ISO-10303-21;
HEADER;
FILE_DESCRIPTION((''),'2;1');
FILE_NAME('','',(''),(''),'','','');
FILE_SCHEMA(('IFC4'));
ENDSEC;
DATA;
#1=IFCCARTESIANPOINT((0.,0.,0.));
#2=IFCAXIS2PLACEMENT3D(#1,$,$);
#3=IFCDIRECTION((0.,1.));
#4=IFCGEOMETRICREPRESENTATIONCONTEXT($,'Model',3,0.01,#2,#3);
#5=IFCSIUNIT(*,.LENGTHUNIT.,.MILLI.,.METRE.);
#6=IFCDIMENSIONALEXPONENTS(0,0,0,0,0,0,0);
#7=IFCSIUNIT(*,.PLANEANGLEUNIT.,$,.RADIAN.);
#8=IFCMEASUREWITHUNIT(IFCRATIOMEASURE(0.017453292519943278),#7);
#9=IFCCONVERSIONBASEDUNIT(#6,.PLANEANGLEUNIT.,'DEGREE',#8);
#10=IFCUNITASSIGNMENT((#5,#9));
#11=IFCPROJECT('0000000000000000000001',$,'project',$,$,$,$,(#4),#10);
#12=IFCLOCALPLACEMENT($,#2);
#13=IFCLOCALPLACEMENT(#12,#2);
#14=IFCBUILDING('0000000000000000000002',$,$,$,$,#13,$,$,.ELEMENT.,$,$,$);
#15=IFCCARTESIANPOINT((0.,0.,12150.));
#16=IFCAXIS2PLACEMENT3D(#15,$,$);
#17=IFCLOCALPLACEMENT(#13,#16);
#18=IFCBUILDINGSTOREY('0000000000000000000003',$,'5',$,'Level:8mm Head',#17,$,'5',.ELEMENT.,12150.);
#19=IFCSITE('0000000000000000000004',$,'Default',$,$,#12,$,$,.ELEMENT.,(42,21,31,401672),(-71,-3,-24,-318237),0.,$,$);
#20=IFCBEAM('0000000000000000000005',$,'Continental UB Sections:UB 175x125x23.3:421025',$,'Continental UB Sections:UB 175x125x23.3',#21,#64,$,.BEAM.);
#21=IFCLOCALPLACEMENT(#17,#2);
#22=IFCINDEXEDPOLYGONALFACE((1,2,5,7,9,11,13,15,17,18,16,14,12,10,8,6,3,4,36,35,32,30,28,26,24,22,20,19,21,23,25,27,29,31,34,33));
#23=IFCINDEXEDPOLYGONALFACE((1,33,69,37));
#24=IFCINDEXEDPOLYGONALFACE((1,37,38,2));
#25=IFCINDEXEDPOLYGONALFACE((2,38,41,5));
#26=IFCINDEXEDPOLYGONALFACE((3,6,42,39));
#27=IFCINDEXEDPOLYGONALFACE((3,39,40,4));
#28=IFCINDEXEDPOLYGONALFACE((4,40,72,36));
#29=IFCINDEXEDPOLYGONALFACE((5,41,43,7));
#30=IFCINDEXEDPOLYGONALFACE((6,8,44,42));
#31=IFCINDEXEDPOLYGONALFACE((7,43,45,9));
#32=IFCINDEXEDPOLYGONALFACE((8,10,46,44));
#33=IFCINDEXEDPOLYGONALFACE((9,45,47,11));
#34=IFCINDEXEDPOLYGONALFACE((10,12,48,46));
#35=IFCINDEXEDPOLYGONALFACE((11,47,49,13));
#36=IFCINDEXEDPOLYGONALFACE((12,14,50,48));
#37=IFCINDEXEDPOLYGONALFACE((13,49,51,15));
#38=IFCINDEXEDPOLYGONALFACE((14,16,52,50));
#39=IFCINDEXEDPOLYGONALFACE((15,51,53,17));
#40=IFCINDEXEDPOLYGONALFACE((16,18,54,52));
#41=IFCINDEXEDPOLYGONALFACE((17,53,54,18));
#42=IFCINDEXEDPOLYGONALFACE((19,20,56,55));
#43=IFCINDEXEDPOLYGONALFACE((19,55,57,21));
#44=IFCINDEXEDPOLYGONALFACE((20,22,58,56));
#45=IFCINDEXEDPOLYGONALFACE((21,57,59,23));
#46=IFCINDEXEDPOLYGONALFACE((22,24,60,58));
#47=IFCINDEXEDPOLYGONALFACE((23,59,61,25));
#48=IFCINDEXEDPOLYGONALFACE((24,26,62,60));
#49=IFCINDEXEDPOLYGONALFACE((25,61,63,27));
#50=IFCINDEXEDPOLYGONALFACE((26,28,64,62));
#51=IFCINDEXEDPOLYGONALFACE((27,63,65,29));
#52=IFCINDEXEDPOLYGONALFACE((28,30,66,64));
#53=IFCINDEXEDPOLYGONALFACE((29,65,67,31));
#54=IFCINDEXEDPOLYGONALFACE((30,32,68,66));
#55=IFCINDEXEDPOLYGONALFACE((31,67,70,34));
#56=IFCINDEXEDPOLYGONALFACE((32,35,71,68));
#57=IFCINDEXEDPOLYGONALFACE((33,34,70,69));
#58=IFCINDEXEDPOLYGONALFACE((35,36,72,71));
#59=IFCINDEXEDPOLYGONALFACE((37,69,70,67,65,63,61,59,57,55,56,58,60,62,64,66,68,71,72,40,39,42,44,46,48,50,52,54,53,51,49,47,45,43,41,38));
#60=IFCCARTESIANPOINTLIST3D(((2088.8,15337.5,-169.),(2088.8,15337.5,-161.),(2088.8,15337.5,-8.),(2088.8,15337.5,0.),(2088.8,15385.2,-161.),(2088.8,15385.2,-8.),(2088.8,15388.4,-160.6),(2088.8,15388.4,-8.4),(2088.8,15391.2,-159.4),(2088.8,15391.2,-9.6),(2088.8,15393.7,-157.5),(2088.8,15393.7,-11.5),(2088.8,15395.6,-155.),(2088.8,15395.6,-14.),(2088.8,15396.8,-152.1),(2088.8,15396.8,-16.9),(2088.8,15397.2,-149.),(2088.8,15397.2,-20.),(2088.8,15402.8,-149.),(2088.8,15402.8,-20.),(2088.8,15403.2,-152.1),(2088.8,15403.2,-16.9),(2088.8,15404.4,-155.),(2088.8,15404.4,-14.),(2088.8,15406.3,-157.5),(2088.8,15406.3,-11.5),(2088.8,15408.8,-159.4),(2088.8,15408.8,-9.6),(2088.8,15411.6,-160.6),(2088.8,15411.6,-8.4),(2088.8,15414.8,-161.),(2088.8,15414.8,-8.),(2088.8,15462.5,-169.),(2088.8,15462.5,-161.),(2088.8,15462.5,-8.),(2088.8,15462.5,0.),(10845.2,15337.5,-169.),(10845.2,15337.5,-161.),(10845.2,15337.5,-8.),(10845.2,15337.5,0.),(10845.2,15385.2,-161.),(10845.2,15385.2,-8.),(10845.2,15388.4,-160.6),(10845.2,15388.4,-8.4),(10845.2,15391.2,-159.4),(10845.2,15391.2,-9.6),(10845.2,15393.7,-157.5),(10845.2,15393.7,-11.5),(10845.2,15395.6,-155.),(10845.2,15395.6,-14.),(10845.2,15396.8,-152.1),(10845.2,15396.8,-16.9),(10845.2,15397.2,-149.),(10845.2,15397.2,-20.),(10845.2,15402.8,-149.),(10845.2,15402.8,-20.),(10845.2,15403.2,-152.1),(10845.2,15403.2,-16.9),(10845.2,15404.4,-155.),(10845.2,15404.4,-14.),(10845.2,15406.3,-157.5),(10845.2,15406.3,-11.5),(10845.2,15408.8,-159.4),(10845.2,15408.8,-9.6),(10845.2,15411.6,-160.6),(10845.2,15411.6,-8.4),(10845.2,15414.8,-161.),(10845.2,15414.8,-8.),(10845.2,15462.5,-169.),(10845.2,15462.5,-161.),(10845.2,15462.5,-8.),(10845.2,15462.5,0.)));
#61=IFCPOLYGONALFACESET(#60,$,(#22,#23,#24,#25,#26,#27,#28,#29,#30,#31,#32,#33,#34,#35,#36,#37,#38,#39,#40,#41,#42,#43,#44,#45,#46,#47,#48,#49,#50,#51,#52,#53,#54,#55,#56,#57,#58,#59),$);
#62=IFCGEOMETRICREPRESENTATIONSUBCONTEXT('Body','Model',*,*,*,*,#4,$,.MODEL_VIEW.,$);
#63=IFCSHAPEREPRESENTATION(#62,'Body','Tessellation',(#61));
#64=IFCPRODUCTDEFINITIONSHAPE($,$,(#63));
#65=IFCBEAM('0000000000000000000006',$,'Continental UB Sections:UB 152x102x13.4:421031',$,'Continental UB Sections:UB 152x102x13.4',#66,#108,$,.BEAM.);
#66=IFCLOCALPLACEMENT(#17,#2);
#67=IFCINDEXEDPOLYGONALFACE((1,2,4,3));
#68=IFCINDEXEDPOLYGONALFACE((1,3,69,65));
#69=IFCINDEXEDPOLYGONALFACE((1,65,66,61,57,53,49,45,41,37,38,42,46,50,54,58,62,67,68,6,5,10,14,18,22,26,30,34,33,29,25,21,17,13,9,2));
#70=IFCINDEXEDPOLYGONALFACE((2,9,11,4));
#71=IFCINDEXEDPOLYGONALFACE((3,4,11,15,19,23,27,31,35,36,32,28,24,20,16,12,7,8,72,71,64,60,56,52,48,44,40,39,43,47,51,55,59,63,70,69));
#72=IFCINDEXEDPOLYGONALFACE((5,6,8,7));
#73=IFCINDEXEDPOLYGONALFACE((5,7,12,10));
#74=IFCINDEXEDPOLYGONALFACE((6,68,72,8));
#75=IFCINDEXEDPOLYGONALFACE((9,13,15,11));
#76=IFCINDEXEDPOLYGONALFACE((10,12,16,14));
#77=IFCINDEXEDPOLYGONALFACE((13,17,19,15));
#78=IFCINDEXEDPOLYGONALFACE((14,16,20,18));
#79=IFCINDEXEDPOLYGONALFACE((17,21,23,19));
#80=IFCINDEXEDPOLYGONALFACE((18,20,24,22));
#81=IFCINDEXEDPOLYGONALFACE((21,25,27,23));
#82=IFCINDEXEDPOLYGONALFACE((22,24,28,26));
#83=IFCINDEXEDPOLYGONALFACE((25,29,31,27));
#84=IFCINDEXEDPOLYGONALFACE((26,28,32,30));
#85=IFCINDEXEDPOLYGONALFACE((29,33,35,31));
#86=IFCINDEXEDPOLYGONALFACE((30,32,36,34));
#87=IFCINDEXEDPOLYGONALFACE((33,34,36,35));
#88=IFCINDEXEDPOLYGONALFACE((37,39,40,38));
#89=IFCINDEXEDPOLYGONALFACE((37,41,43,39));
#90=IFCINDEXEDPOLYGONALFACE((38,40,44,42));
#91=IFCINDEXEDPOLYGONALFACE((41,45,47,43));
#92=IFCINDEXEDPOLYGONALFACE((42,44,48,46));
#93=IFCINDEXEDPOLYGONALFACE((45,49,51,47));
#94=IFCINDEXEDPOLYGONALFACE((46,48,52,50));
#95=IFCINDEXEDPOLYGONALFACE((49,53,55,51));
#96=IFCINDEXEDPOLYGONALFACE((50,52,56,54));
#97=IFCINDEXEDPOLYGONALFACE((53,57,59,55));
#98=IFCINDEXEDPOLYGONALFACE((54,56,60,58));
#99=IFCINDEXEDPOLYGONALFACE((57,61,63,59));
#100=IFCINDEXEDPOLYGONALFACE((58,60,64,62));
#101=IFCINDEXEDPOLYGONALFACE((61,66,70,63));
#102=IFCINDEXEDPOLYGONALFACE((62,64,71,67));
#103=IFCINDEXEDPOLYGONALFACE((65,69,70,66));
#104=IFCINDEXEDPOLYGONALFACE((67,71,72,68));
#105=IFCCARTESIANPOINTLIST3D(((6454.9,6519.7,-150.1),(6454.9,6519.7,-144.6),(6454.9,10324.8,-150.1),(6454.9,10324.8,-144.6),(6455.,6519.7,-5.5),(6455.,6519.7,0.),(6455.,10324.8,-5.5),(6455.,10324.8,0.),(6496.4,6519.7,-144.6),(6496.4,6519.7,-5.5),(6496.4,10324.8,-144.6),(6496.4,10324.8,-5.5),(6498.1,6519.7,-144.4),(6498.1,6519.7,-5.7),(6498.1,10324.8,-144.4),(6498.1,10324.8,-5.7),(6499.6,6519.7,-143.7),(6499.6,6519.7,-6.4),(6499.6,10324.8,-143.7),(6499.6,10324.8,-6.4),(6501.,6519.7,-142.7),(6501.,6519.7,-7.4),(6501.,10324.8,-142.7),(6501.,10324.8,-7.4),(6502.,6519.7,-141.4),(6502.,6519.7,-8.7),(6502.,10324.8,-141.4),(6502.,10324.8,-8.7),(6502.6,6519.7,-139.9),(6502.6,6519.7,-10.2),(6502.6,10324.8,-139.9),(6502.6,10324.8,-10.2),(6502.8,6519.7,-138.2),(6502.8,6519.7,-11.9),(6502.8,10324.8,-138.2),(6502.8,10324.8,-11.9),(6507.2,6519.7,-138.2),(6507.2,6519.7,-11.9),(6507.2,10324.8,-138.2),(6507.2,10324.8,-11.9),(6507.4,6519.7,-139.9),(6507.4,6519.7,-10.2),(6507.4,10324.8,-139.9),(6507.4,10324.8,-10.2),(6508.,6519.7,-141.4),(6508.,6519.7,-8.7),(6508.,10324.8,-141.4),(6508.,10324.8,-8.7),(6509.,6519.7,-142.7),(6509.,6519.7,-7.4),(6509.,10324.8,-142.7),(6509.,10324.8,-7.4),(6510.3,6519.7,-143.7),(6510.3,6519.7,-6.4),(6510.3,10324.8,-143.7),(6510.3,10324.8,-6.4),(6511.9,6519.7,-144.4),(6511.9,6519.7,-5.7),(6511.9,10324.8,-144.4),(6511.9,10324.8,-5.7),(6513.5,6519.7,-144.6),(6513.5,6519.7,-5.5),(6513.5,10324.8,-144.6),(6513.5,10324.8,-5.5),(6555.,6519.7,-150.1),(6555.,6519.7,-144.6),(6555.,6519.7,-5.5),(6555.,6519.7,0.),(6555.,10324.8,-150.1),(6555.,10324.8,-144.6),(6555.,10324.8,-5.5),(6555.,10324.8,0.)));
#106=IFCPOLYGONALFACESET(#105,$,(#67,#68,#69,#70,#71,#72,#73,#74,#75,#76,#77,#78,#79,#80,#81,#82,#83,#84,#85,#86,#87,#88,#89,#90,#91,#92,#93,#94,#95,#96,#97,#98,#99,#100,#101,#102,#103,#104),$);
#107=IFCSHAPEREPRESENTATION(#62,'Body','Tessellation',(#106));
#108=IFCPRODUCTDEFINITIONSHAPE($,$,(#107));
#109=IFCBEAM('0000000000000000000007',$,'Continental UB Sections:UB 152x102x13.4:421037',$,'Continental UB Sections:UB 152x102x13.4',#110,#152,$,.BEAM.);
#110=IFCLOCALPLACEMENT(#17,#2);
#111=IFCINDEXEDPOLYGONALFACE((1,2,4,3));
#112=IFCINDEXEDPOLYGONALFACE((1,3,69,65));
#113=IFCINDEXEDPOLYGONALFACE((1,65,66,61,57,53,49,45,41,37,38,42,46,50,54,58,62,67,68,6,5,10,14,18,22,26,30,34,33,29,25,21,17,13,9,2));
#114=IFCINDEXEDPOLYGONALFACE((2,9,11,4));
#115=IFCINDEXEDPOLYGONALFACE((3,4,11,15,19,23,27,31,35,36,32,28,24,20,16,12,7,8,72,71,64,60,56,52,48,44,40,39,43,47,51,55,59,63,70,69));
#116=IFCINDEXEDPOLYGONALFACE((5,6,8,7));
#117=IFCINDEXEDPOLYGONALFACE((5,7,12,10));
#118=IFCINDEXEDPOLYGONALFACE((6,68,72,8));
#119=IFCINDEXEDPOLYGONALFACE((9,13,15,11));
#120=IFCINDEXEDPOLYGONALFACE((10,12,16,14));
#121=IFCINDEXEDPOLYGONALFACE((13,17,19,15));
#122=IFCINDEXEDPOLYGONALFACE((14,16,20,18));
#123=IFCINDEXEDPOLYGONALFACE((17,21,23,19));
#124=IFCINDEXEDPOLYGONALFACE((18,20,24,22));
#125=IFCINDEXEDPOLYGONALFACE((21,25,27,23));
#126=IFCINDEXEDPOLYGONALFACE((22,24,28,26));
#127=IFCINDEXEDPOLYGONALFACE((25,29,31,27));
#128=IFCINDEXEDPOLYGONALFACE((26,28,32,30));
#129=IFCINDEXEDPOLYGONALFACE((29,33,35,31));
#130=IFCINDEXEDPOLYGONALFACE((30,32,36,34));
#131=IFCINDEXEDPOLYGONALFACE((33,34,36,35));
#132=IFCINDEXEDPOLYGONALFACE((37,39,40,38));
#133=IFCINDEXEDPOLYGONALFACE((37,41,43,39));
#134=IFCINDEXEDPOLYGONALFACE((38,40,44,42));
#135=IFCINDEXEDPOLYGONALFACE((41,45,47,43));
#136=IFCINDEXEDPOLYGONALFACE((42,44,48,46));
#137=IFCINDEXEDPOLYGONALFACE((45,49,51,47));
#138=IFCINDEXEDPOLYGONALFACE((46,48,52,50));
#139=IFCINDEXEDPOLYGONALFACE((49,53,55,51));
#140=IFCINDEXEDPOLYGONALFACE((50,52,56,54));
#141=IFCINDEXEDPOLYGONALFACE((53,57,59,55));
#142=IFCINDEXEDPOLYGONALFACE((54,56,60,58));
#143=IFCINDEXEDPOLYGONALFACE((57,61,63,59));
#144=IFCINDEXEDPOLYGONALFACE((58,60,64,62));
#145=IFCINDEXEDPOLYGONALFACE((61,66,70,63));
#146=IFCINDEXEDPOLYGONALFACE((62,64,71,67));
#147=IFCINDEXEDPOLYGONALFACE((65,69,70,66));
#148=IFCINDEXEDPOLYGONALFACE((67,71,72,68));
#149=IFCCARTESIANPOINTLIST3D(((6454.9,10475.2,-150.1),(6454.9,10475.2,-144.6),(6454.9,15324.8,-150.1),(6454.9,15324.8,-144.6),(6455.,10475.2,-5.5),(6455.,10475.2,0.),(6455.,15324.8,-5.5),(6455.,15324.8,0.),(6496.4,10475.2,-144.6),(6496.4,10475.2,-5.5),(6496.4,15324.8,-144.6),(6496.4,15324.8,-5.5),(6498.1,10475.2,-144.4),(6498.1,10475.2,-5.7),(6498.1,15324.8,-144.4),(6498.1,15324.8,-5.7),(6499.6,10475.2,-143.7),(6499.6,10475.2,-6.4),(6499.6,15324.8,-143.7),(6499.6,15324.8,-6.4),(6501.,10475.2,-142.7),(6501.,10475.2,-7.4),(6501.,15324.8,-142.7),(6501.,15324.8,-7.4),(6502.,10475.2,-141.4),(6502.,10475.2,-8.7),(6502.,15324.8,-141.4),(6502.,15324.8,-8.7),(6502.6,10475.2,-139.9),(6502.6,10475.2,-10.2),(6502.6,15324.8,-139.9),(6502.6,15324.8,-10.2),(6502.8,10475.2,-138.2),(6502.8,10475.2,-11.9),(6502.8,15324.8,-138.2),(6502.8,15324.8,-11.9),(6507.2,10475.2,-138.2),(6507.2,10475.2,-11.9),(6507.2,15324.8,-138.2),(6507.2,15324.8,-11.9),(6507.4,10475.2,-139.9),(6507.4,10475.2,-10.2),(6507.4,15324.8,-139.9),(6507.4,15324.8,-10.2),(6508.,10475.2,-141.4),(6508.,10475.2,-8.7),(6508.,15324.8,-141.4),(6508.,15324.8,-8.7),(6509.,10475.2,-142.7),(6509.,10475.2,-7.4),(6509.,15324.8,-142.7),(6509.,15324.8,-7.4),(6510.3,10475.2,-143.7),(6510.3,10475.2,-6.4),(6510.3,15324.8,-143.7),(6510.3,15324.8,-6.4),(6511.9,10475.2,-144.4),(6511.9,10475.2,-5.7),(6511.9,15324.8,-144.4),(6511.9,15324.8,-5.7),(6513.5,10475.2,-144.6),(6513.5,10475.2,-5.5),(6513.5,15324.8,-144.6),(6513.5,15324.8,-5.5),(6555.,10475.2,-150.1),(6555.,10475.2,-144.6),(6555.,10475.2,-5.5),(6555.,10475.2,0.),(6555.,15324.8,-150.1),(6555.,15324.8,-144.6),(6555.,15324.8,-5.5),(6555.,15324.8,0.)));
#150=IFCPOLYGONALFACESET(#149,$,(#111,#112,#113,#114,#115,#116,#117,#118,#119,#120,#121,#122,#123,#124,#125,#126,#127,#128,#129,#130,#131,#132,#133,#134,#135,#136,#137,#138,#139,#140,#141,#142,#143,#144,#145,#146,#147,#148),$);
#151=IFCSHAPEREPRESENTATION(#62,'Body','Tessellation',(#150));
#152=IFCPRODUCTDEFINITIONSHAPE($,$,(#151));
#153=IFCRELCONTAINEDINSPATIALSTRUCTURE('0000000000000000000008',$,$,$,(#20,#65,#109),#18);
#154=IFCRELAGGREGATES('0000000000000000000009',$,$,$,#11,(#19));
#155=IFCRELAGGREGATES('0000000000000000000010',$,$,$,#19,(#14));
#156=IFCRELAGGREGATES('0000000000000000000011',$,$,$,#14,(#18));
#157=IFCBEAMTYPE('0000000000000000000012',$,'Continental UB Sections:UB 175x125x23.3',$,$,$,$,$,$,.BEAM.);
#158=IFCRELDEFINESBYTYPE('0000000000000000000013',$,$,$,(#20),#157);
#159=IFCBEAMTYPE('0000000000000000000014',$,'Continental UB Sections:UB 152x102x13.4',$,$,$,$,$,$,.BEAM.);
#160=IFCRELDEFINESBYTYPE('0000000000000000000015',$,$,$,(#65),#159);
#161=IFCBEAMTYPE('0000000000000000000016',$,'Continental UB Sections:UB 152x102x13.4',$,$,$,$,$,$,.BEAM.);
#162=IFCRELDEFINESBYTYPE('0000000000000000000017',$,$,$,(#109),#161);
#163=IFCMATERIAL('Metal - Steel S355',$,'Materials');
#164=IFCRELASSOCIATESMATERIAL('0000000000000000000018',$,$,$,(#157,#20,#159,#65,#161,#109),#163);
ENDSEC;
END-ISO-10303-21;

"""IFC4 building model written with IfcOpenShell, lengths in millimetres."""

from ifc_helpers import new_model, entity, si_unit, converted_unit, direction, frame, origin, place, context, subcontext, project, spatial, line, arc, indexed_curve, outline, extrude, source, transform, mapped, material, type_object, type_shapes, element, save


model = new_model("IFC4")

# Units and contexts
model_context = context("Model", 3, precision=0.01, world=origin(), true_north=direction((0.0, 1.0)))
body_context = subcontext(model_context, "Body", "Model", "MODEL_VIEW")
ifc_project = project(units=[si_unit("LENGTHUNIT", "METRE", prefix="MILLI"), converted_unit("PLANEANGLEUNIT", "DEGREE", entity("IfcRatioMeasure", 0.017453292519943278), si_unit("PLANEANGLEUNIT", "RADIAN"), dimensions=[0, 0, 0, 0, 0, 0, 0])], contexts=[model_context])

# Site, building, storey
site_placement = place(None, origin())
site = spatial("IfcSite", under=ifc_project, at=site_placement, Name="Default", CompositionType="ELEMENT", RefLatitude=(42, 21, 31, 401672), RefLongitude=(-71, -3, -24, -318237), RefElevation=0.0)
building_placement = place(site_placement, origin())
building = spatial("IfcBuilding", under=site, at=building_placement, CompositionType="ELEMENT")
storey_placement = place(building_placement, frame((0.0, 0.0, 12150.0)))
storey = spatial("IfcBuildingStorey", under=building, at=storey_placement, Name="5", ObjectType="Level:8mm Head", LongName="5", CompositionType="ELEMENT", Elevation=12150.0)

# Beams
ifc_material = material(Name="Metal - Steel S355", Category="Materials")
beam_type_1 = type_object("IfcBeamType", Name="Continental UB Sections:UB 175x125x23.3", PredefinedType="BEAM", material=ifc_material)
shared_shape_1 = source(origin(), body_context, "Body", "SweptSolid", [
    extrude(outline(indexed_curve([(-84.5, -62.5), (-76.5, -62.5), (-76.5, -14.8), (-73.0, -6.3), (-64.5, -2.7), (64.5, -2.7), (73.0, -6.3), (76.5, -14.7), (76.5, -62.5), (84.5, -62.5), (84.5, 62.5), (76.5, 62.5), (76.5, 14.8), (73.0, 6.3), (64.5, 2.8), (-64.5, 2.8), (-73.0, 6.3), (-76.5, 14.8), (-76.5, 62.5), (-84.5, 62.5)], segments=[line(1, 2, 3), arc(3, 4, 5), line(5, 6), arc(6, 7, 8), line(8, 9, 10, 11, 12, 13), arc(13, 14, 15), line(15, 16), arc(16, 17, 18), line(18, 19, 20, 1)], self_intersect=False)), frame((-4416.2, 0.0, 0.0), z_axis=(1.0, 0.0, 0.0), x_axis=(0.0, 0.0, -1.0)), (0.0, 0.0, 1.0), 8756.4),
])
type_shapes(beam_type_1, [shared_shape_1])
for number, where, name in (
    (1, (6505.0, 15400.0, -84.5), "Continental UB Sections:UB 175x125x23.3:421025"),
):
    element("IfcBeam", number, at=place(storey_placement, frame(where)), inside=storey, type_object=beam_type_1, material=ifc_material, Name=name, ObjectType="Continental UB Sections:UB 175x125x23.3", PredefinedType="BEAM", context=body_context, shape_type="MappedRepresentation", body=[
        mapped(shared_shape_1, transform((0.0, 0.0, 0.0), scale=1.0)),
    ])
beam_type_2 = type_object("IfcBeamType", Name="Continental UB Sections:UB 152x102x13.4", PredefinedType="BEAM", material=ifc_material)
shared_shape_2 = source(origin(), body_context, "Body", "SweptSolid", [
    extrude(outline(indexed_curve([(-75.0, -50.1), (-69.6, -50.1), (-69.6, -8.5), (-67.7, -4.0), (-63.2, -2.1), (63.1, -2.1), (67.7, -4.0), (69.5, -8.5), (69.5, -50.1), (75.1, -50.1), (75.1, 50.1), (69.5, 50.1), (69.5, 8.6), (67.7, 4.0), (63.1, 2.2), (-63.2, 2.2), (-67.7, 4.0), (-69.6, 8.6), (-69.6, 50.0), (-75.0, 50.0)], segments=[line(1, 2, 3), arc(3, 4, 5), line(5, 6), arc(6, 7, 8), line(8, 9, 10, 11, 12, 13), arc(13, 14, 15), line(15, 16), arc(16, 17, 18), line(18, 19, 20, 1)], self_intersect=False)), frame((-1805.3, 0.0, 0.0), z_axis=(1.0, 0.0, 0.0), x_axis=(0.0, 0.0, -1.0)), (0.0, 0.0, 1.0), 3805.1),
])
type_shapes(beam_type_2, [shared_shape_2])
beam_1_placement = place(storey_placement, frame((6505.0, 8325.0, -75.1), z_axis=(0.0, 0.0, 1.0), x_axis=(0.0, 1.0, 0.0)))
element("IfcBeam", 2, at=beam_1_placement, inside=storey, type_object=beam_type_2, material=ifc_material, Name="Continental UB Sections:UB 152x102x13.4:421031", ObjectType="Continental UB Sections:UB 152x102x13.4", PredefinedType="BEAM", context=body_context, shape_type="MappedRepresentation", body=[
    mapped(shared_shape_2, transform((0.0, 0.0, 0.0), scale=1.0)),
])
beam_type_3 = type_object("IfcBeamType", Name="Continental UB Sections:UB 152x102x13.4", PredefinedType="BEAM", material=ifc_material)
shared_shape_3 = source(origin(), body_context, "Body", "SweptSolid", [
    extrude(outline(indexed_curve([(-75.0, -50.1), (-69.6, -50.1), (-69.6, -8.5), (-67.7, -4.0), (-63.2, -2.1), (63.1, -2.1), (67.7, -4.0), (69.5, -8.5), (69.5, -50.1), (75.1, -50.1), (75.1, 50.1), (69.5, 50.1), (69.5, 8.6), (67.7, 4.0), (63.1, 2.2), (-63.2, 2.2), (-67.7, 4.0), (-69.6, 8.6), (-69.6, 50.0), (-75.0, 50.0)], segments=[line(1, 2, 3), arc(3, 4, 5), line(5, 6), arc(6, 7, 8), line(8, 9, 10, 11, 12, 13), arc(13, 14, 15), line(15, 16), arc(16, 17, 18), line(18, 19, 20, 1)], self_intersect=False)), frame((-2424.8, 0.0, 0.0), z_axis=(1.0, 0.0, 0.0), x_axis=(0.0, 0.0, -1.0)), (0.0, 0.0, 1.0), 4849.6),
])
type_shapes(beam_type_3, [shared_shape_3])
for number, where, z_axis, x_axis, name in (
    (3, (6505.0, 12900.0, -75.1), (0.0, 0.0, 1.0), (0.0, 1.0, 0.0), "Continental UB Sections:UB 152x102x13.4:421037"),
):
    element("IfcBeam", number, at=place(storey_placement, frame(where, z_axis=z_axis, x_axis=x_axis)), inside=storey, type_object=beam_type_3, material=ifc_material, Name=name, ObjectType="Continental UB Sections:UB 152x102x13.4", PredefinedType="BEAM", context=body_context, shape_type="MappedRepresentation", body=[
        mapped(shared_shape_3, transform((0.0, 0.0, 0.0), scale=1.0)),
    ])

save(model, "model.ifc")
